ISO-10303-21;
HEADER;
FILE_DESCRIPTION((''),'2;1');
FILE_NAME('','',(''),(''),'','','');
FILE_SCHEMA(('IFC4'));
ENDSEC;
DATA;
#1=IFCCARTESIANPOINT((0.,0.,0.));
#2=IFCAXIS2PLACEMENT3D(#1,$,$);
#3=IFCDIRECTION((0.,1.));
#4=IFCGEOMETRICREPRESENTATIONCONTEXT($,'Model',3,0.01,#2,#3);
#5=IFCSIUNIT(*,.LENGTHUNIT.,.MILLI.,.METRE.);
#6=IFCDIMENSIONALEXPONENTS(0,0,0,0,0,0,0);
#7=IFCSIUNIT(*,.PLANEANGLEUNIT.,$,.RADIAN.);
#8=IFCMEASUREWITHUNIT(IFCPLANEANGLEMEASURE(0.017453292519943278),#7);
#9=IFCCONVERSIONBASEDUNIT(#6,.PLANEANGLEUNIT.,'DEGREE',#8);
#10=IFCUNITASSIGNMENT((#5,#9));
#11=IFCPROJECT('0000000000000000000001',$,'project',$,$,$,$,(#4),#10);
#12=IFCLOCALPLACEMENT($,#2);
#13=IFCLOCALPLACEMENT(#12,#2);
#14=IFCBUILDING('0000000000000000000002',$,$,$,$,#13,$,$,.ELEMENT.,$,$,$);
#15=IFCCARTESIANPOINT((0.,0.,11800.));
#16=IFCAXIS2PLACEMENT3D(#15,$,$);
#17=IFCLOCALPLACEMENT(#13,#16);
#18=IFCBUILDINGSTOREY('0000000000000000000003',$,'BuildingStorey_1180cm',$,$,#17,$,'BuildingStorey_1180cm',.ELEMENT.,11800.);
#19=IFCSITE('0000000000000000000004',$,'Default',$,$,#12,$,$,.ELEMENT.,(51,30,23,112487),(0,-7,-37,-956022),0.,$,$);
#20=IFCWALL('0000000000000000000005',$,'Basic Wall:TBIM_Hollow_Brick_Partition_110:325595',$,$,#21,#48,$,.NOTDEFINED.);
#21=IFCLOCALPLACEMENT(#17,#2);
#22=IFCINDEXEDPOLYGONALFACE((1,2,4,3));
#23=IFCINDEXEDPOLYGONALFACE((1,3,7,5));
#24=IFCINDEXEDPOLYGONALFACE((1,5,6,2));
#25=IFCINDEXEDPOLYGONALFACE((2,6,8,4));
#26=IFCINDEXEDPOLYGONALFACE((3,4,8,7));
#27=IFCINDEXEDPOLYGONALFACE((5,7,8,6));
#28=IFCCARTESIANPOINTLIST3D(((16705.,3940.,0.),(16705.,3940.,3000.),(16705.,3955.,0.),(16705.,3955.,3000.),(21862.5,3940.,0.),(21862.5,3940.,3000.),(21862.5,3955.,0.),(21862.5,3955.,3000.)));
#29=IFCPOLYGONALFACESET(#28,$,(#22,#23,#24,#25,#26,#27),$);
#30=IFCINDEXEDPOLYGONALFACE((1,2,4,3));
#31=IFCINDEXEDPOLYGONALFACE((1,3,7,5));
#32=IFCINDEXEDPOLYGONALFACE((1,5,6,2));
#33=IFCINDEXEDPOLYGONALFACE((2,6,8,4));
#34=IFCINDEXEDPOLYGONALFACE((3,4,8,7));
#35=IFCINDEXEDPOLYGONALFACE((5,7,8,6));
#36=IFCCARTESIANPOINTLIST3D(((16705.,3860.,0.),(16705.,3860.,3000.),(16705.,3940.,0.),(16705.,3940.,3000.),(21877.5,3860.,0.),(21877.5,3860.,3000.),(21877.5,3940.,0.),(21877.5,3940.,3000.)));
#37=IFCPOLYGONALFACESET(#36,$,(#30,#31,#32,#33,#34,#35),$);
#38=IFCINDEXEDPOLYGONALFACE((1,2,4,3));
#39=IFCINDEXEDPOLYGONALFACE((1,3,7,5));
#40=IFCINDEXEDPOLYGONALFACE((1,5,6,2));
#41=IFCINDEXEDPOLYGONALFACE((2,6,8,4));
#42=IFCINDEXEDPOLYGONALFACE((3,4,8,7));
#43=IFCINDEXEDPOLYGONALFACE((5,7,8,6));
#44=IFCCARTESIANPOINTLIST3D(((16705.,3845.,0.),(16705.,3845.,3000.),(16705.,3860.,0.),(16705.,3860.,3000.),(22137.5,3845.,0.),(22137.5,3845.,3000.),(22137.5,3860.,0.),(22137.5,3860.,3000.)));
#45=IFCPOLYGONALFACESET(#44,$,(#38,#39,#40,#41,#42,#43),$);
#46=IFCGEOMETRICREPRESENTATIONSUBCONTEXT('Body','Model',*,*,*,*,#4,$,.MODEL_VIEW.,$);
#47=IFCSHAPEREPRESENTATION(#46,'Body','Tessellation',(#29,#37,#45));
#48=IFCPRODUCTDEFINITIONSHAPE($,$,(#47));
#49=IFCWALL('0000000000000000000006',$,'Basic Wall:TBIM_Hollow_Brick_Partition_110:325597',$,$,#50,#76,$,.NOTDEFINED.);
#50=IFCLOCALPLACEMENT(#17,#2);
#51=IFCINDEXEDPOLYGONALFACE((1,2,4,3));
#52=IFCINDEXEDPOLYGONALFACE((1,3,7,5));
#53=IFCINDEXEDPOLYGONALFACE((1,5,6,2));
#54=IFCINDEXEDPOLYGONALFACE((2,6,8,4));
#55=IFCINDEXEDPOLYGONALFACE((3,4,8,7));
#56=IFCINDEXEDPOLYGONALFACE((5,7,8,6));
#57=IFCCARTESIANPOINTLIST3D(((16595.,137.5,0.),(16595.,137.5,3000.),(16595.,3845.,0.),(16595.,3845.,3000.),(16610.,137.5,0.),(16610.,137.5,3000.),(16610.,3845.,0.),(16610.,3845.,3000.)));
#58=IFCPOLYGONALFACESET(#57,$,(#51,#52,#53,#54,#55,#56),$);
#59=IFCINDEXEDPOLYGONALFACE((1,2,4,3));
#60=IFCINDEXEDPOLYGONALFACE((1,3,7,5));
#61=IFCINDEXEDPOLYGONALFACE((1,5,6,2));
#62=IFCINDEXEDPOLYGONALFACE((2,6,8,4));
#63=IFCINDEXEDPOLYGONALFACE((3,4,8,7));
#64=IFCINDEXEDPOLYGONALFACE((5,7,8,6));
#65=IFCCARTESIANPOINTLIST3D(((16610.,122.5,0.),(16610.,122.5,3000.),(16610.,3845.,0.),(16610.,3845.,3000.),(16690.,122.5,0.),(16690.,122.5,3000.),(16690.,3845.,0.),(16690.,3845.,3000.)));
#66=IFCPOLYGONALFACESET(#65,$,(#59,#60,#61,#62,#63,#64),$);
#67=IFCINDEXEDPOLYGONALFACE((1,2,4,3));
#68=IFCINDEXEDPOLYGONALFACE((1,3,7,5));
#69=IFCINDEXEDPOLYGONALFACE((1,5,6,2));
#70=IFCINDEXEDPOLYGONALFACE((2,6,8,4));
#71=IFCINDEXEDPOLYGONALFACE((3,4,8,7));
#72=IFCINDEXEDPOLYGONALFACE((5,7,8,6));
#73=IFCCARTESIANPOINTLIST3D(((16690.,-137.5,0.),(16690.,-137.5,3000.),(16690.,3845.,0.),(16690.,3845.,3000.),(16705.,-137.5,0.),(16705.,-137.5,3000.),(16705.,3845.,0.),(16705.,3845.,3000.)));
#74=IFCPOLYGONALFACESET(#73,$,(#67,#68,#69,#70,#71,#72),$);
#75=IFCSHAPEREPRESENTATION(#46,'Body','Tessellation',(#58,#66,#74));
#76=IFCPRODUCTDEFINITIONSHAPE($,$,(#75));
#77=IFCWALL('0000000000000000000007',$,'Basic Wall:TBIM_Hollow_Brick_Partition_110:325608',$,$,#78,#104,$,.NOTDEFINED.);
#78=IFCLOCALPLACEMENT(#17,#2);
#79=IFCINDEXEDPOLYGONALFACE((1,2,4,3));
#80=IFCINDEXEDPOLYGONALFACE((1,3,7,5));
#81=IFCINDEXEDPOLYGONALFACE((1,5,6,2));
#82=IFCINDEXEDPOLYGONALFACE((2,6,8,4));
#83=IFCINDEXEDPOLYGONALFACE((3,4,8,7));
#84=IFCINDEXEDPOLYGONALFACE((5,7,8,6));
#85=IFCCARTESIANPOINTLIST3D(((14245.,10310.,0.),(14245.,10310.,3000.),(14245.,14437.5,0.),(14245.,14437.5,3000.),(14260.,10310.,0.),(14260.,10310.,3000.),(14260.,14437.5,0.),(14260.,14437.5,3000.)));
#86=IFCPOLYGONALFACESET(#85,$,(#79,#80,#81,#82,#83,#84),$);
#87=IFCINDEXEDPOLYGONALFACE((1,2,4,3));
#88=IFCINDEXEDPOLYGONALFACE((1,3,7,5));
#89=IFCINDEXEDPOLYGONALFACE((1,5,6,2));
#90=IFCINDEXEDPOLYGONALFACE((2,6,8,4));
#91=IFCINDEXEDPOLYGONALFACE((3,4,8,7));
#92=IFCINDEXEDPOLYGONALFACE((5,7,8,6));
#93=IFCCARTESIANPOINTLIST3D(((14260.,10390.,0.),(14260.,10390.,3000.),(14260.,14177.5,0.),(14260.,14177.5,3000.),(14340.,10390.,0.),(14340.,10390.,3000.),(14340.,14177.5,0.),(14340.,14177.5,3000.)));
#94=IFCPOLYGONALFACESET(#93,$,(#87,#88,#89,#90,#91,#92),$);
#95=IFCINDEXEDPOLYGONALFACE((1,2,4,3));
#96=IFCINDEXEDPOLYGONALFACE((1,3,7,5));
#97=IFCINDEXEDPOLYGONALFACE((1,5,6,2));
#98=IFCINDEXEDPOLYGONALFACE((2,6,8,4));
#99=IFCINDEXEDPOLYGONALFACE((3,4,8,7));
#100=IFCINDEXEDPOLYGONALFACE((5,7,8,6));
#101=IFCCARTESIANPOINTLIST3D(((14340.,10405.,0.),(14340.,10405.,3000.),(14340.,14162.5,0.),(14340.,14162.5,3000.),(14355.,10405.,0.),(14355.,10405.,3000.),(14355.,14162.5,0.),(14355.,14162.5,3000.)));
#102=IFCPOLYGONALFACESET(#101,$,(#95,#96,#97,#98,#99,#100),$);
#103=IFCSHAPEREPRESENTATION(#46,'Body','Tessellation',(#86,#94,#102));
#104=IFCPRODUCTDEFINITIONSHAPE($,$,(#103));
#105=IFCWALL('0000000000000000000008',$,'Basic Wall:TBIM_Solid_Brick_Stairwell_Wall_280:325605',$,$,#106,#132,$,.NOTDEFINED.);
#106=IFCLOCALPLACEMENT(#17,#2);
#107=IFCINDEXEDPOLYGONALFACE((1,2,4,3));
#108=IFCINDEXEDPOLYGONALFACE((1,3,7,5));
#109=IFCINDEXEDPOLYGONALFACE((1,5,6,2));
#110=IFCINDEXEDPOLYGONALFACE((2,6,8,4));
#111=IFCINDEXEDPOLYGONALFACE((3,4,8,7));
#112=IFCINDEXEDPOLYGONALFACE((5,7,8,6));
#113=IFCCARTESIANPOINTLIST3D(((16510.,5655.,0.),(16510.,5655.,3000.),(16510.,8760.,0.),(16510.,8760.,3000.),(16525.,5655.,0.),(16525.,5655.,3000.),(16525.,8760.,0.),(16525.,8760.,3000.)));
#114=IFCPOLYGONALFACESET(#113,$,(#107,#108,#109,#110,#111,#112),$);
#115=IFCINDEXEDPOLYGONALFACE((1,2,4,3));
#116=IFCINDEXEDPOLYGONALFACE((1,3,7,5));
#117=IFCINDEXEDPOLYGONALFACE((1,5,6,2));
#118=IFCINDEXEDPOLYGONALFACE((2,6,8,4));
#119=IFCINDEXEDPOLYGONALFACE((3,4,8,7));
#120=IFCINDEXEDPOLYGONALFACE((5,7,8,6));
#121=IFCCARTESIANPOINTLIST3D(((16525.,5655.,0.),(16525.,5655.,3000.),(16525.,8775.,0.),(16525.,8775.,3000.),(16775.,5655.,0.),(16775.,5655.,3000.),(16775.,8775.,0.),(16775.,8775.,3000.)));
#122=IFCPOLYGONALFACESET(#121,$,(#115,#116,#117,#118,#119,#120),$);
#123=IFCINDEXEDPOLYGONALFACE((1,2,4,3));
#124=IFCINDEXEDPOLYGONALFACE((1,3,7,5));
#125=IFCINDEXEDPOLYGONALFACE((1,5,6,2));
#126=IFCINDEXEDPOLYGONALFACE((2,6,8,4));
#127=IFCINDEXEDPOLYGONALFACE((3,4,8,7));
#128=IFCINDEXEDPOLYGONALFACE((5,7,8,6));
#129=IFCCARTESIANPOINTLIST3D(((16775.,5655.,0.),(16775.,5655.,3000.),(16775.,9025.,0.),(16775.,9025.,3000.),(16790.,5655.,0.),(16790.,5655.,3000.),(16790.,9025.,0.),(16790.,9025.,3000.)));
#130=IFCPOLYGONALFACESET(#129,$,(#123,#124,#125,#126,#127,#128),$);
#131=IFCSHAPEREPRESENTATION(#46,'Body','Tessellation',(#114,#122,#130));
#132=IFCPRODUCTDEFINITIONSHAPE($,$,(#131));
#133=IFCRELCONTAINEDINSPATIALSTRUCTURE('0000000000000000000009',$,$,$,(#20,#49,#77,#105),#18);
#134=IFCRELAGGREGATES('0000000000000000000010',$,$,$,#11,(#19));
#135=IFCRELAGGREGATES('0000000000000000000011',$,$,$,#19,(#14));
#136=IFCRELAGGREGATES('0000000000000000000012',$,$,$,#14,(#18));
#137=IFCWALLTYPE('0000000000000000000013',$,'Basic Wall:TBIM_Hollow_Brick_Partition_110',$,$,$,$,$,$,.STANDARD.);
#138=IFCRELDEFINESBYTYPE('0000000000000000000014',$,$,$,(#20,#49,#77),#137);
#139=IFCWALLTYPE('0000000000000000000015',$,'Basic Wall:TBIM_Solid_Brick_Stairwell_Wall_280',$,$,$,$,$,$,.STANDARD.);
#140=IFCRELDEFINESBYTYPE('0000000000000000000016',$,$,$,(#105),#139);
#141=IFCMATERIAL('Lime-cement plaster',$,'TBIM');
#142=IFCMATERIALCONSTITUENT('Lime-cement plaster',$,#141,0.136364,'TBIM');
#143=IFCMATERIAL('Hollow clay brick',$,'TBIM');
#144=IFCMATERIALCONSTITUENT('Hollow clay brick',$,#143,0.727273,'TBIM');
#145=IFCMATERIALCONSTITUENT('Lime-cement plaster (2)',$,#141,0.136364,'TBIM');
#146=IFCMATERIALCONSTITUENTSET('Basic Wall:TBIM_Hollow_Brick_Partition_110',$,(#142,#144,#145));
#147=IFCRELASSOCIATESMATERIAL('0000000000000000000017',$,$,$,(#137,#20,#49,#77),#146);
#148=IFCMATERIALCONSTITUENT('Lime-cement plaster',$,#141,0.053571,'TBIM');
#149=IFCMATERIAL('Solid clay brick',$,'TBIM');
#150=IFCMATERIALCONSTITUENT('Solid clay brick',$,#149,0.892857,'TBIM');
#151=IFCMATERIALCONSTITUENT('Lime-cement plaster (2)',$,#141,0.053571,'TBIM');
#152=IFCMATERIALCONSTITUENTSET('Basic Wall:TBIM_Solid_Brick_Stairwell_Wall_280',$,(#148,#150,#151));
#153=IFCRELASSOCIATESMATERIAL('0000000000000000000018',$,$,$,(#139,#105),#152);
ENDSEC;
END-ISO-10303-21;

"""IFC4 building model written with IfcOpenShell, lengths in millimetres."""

from ifc_helpers import new_model, entity, si_unit, converted_unit, direction, frame, origin, place, context, subcontext, project, spatial, indexed_curve, outline, extrude, material, constituent, constituent_set, type_object, element, save


model = new_model("IFC4")

# Units and contexts
model_context = context("Model", 3, precision=0.01, world=origin(), true_north=direction((0.0, 1.0)))
body_context = subcontext(model_context, "Body", "Model", "MODEL_VIEW")
ifc_project = project(units=[si_unit("LENGTHUNIT", "METRE", prefix="MILLI"), converted_unit("PLANEANGLEUNIT", "DEGREE", entity("IfcPlaneAngleMeasure", 0.017453292519943278), si_unit("PLANEANGLEUNIT", "RADIAN"), dimensions=[0, 0, 0, 0, 0, 0, 0])], contexts=[model_context])

# Site, building, storey
site_placement = place(None, origin())
site = spatial("IfcSite", under=ifc_project, at=site_placement, Name="Default", CompositionType="ELEMENT", RefLatitude=(51, 30, 23, 112487), RefLongitude=(0, -7, -37, -956022), RefElevation=0.0)
building_placement = place(site_placement, origin())
building = spatial("IfcBuilding", under=site, at=building_placement, CompositionType="ELEMENT")
storey_placement = place(building_placement, frame((0.0, 0.0, 11800.0)))
storey = spatial("IfcBuildingStorey", under=building, at=storey_placement, Name="BuildingStorey_1180cm", LongName="BuildingStorey_1180cm", CompositionType="ELEMENT", Elevation=11800.0)

# Shared definitions
ifc_material_1 = material(Name="Hollow clay brick", Category="TBIM")
ifc_material_2 = material(Name="Lime-cement plaster", Category="TBIM")
ifc_constituent_1 = constituent(ifc_material_2, Name="Lime-cement plaster", Category="TBIM", fraction=0.136364)
ifc_constituent_2 = constituent(ifc_material_1, Name="Hollow clay brick", Category="TBIM", fraction=0.727273)
ifc_constituent_3 = constituent(ifc_material_2, Name="Lime-cement plaster (2)", Category="TBIM", fraction=0.136364)
ifc_constituent_set_1 = constituent_set(constituents=[ifc_constituent_1, ifc_constituent_2, ifc_constituent_3], Name="Basic Wall:TBIM_Hollow_Brick_Partition_110")
wall_type_1 = type_object("IfcWallType", Name="Basic Wall:TBIM_Hollow_Brick_Partition_110", PredefinedType="STANDARD", material=ifc_constituent_set_1)

# Walls
wall_1_placement = place(storey_placement, frame((16705.0, 3900.0, 0.0)))
element("IfcWall", 1, at=wall_1_placement, inside=storey, type_object=wall_type_1, material=ifc_constituent_set_1, Name="Basic Wall:TBIM_Hollow_Brick_Partition_110:325595", PredefinedType="NOTDEFINED", context=body_context, shape_type="SweptSolid", body=[
    extrude(outline(indexed_curve([(-7.5, -2578.8), (7.5, -2578.8), (7.5, 2578.8), (-7.5, 2578.8), (-7.5, -2578.8)], self_intersect=False)), frame((2578.8, 47.5, 0.0), z_axis=(0.0, 0.0, 1.0), x_axis=(0.0, -1.0, 0.0)), (0.0, 0.0, 1.0), 3000.0),
    extrude(outline(indexed_curve([(-2586.3, -40.0), (2586.3, -40.0), (2586.3, 40.0), (-2586.3, 40.0), (-2586.3, -40.0)], self_intersect=False)), frame((2586.3, 0.0, 0.0)), (0.0, 0.0, 1.0), 3000.0),
    extrude(outline(indexed_curve([(-7.5, -2716.3), (7.5, -2716.3), (7.5, 2716.3), (-7.5, 2716.3), (-7.5, -2716.3)], self_intersect=False)), frame((2716.3, -47.5, 0.0), z_axis=(0.0, 0.0, 1.0), x_axis=(0.0, 1.0, 0.0)), (0.0, 0.0, 1.0), 3000.0),
])
wall_2_placement = place(storey_placement, frame((16650.0, 137.5, 0.0), z_axis=(0.0, 0.0, 1.0), x_axis=(0.0, 1.0, 0.0)))
element("IfcWall", 2, at=wall_2_placement, inside=storey, type_object=wall_type_1, material=ifc_constituent_set_1, Name="Basic Wall:TBIM_Hollow_Brick_Partition_110:325597", PredefinedType="NOTDEFINED", context=body_context, shape_type="SweptSolid", body=[
    extrude(outline(indexed_curve([(-7.5, -1853.8), (7.5, -1853.8), (7.5, 1853.8), (-7.5, 1853.8), (-7.5, -1853.8)], self_intersect=False)), frame((1853.8, 47.5, 0.0), z_axis=(0.0, 0.0, 1.0), x_axis=(0.0, -1.0, 0.0)), (0.0, 0.0, 1.0), 3000.0),
    extrude(outline(indexed_curve([(-1861.3, -40.0), (1861.3, -40.0), (1861.3, 40.0), (-1861.3, 40.0), (-1861.3, -40.0)], self_intersect=False)), frame((1846.3, 0.0, 0.0)), (0.0, 0.0, 1.0), 3000.0),
    extrude(outline(indexed_curve([(-7.5, -1991.3), (7.5, -1991.3), (7.5, 1991.3), (-7.5, 1991.3), (-7.5, -1991.3)], self_intersect=False)), frame((1716.3, -47.5, 0.0), z_axis=(0.0, 0.0, 1.0), x_axis=(0.0, 1.0, 0.0)), (0.0, 0.0, 1.0), 3000.0),
])

# Wall
wall_3_placement = place(storey_placement, frame((14300.0, 10405.0, 0.0), z_axis=(0.0, 0.0, 1.0), x_axis=(0.0, 1.0, 0.0)))
element("IfcWall", 3, at=wall_3_placement, inside=storey, type_object=wall_type_1, material=ifc_constituent_set_1, Name="Basic Wall:TBIM_Hollow_Brick_Partition_110:325608", PredefinedType="NOTDEFINED", context=body_context, shape_type="SweptSolid", body=[
    extrude(outline(indexed_curve([(-7.5, -2063.8), (7.5, -2063.8), (7.5, 2063.7), (-7.5, 2063.7), (-7.5, -2063.8)], self_intersect=False)), frame((1968.8, 47.5, 0.0), z_axis=(0.0, 0.0, 1.0), x_axis=(0.0, -1.0, 0.0)), (0.0, 0.0, 1.0), 3000.0),
    extrude(outline(indexed_curve([(-1893.8, -40.0), (1893.8, -40.0), (1893.8, 40.0), (-1893.8, 40.0), (-1893.8, -40.0)], self_intersect=False)), frame((1878.7, 0.0, 0.0)), (0.0, 0.0, 1.0), 3000.0),
    extrude(outline(indexed_curve([(-7.5, -1878.7), (7.5, -1878.7), (7.5, 1878.7), (-7.5, 1878.7), (-7.5, -1878.7)], self_intersect=False)), frame((1878.7, -47.5, 0.0), z_axis=(0.0, 0.0, 1.0), x_axis=(0.0, 1.0, 0.0)), (0.0, 0.0, 1.0), 3000.0),
])

# Wall
ifc_constituent_4 = constituent(ifc_material_2, Name="Lime-cement plaster", Category="TBIM", fraction=0.053571)
ifc_material_3 = material(Name="Solid clay brick", Category="TBIM")
ifc_constituent_5 = constituent(ifc_material_3, Name="Solid clay brick", Category="TBIM", fraction=0.892857)
ifc_constituent_6 = constituent(ifc_material_2, Name="Lime-cement plaster (2)", Category="TBIM", fraction=0.053571)
ifc_constituent_set_2 = constituent_set(constituents=[ifc_constituent_4, ifc_constituent_5, ifc_constituent_6], Name="Basic Wall:TBIM_Solid_Brick_Stairwell_Wall_280")
wall_type_2 = type_object("IfcWallType", Name="Basic Wall:TBIM_Solid_Brick_Stairwell_Wall_280", PredefinedType="STANDARD", material=ifc_constituent_set_2)
wall_4_placement = place(storey_placement, frame((16650.0, 5655.0, 0.0), z_axis=(0.0, 0.0, 1.0), x_axis=(0.0, 1.0, 0.0)))
element("IfcWall", 4, at=wall_4_placement, inside=storey, type_object=wall_type_2, material=ifc_constituent_set_2, Name="Basic Wall:TBIM_Solid_Brick_Stairwell_Wall_280:325605", PredefinedType="NOTDEFINED", context=body_context, shape_type="SweptSolid", body=[
    extrude(outline(indexed_curve([(-7.5, -1552.5), (7.5, -1552.5), (7.5, 1552.5), (-7.5, 1552.5), (-7.5, -1552.5)], self_intersect=False)), frame((1552.5, 132.5, 0.0), z_axis=(0.0, 0.0, 1.0), x_axis=(0.0, -1.0, 0.0)), (0.0, 0.0, 1.0), 3000.0),
    extrude(outline(indexed_curve([(-1560.0, -125.0), (1560.0, -125.0), (1560.0, 125.0), (-1560.0, 125.0), (-1560.0, -125.0)], self_intersect=False)), frame((1560.0, 0.0, 0.0)), (0.0, 0.0, 1.0), 3000.0),
    extrude(outline(indexed_curve([(-7.5, -1685.0), (7.5, -1685.0), (7.5, 1685.0), (-7.5, 1685.0), (-7.5, -1685.0)], self_intersect=False)), frame((1685.0, -132.5, 0.0), z_axis=(0.0, 0.0, 1.0), x_axis=(0.0, 1.0, 0.0)), (0.0, 0.0, 1.0), 3000.0),
])

save(model, "model.ifc")
